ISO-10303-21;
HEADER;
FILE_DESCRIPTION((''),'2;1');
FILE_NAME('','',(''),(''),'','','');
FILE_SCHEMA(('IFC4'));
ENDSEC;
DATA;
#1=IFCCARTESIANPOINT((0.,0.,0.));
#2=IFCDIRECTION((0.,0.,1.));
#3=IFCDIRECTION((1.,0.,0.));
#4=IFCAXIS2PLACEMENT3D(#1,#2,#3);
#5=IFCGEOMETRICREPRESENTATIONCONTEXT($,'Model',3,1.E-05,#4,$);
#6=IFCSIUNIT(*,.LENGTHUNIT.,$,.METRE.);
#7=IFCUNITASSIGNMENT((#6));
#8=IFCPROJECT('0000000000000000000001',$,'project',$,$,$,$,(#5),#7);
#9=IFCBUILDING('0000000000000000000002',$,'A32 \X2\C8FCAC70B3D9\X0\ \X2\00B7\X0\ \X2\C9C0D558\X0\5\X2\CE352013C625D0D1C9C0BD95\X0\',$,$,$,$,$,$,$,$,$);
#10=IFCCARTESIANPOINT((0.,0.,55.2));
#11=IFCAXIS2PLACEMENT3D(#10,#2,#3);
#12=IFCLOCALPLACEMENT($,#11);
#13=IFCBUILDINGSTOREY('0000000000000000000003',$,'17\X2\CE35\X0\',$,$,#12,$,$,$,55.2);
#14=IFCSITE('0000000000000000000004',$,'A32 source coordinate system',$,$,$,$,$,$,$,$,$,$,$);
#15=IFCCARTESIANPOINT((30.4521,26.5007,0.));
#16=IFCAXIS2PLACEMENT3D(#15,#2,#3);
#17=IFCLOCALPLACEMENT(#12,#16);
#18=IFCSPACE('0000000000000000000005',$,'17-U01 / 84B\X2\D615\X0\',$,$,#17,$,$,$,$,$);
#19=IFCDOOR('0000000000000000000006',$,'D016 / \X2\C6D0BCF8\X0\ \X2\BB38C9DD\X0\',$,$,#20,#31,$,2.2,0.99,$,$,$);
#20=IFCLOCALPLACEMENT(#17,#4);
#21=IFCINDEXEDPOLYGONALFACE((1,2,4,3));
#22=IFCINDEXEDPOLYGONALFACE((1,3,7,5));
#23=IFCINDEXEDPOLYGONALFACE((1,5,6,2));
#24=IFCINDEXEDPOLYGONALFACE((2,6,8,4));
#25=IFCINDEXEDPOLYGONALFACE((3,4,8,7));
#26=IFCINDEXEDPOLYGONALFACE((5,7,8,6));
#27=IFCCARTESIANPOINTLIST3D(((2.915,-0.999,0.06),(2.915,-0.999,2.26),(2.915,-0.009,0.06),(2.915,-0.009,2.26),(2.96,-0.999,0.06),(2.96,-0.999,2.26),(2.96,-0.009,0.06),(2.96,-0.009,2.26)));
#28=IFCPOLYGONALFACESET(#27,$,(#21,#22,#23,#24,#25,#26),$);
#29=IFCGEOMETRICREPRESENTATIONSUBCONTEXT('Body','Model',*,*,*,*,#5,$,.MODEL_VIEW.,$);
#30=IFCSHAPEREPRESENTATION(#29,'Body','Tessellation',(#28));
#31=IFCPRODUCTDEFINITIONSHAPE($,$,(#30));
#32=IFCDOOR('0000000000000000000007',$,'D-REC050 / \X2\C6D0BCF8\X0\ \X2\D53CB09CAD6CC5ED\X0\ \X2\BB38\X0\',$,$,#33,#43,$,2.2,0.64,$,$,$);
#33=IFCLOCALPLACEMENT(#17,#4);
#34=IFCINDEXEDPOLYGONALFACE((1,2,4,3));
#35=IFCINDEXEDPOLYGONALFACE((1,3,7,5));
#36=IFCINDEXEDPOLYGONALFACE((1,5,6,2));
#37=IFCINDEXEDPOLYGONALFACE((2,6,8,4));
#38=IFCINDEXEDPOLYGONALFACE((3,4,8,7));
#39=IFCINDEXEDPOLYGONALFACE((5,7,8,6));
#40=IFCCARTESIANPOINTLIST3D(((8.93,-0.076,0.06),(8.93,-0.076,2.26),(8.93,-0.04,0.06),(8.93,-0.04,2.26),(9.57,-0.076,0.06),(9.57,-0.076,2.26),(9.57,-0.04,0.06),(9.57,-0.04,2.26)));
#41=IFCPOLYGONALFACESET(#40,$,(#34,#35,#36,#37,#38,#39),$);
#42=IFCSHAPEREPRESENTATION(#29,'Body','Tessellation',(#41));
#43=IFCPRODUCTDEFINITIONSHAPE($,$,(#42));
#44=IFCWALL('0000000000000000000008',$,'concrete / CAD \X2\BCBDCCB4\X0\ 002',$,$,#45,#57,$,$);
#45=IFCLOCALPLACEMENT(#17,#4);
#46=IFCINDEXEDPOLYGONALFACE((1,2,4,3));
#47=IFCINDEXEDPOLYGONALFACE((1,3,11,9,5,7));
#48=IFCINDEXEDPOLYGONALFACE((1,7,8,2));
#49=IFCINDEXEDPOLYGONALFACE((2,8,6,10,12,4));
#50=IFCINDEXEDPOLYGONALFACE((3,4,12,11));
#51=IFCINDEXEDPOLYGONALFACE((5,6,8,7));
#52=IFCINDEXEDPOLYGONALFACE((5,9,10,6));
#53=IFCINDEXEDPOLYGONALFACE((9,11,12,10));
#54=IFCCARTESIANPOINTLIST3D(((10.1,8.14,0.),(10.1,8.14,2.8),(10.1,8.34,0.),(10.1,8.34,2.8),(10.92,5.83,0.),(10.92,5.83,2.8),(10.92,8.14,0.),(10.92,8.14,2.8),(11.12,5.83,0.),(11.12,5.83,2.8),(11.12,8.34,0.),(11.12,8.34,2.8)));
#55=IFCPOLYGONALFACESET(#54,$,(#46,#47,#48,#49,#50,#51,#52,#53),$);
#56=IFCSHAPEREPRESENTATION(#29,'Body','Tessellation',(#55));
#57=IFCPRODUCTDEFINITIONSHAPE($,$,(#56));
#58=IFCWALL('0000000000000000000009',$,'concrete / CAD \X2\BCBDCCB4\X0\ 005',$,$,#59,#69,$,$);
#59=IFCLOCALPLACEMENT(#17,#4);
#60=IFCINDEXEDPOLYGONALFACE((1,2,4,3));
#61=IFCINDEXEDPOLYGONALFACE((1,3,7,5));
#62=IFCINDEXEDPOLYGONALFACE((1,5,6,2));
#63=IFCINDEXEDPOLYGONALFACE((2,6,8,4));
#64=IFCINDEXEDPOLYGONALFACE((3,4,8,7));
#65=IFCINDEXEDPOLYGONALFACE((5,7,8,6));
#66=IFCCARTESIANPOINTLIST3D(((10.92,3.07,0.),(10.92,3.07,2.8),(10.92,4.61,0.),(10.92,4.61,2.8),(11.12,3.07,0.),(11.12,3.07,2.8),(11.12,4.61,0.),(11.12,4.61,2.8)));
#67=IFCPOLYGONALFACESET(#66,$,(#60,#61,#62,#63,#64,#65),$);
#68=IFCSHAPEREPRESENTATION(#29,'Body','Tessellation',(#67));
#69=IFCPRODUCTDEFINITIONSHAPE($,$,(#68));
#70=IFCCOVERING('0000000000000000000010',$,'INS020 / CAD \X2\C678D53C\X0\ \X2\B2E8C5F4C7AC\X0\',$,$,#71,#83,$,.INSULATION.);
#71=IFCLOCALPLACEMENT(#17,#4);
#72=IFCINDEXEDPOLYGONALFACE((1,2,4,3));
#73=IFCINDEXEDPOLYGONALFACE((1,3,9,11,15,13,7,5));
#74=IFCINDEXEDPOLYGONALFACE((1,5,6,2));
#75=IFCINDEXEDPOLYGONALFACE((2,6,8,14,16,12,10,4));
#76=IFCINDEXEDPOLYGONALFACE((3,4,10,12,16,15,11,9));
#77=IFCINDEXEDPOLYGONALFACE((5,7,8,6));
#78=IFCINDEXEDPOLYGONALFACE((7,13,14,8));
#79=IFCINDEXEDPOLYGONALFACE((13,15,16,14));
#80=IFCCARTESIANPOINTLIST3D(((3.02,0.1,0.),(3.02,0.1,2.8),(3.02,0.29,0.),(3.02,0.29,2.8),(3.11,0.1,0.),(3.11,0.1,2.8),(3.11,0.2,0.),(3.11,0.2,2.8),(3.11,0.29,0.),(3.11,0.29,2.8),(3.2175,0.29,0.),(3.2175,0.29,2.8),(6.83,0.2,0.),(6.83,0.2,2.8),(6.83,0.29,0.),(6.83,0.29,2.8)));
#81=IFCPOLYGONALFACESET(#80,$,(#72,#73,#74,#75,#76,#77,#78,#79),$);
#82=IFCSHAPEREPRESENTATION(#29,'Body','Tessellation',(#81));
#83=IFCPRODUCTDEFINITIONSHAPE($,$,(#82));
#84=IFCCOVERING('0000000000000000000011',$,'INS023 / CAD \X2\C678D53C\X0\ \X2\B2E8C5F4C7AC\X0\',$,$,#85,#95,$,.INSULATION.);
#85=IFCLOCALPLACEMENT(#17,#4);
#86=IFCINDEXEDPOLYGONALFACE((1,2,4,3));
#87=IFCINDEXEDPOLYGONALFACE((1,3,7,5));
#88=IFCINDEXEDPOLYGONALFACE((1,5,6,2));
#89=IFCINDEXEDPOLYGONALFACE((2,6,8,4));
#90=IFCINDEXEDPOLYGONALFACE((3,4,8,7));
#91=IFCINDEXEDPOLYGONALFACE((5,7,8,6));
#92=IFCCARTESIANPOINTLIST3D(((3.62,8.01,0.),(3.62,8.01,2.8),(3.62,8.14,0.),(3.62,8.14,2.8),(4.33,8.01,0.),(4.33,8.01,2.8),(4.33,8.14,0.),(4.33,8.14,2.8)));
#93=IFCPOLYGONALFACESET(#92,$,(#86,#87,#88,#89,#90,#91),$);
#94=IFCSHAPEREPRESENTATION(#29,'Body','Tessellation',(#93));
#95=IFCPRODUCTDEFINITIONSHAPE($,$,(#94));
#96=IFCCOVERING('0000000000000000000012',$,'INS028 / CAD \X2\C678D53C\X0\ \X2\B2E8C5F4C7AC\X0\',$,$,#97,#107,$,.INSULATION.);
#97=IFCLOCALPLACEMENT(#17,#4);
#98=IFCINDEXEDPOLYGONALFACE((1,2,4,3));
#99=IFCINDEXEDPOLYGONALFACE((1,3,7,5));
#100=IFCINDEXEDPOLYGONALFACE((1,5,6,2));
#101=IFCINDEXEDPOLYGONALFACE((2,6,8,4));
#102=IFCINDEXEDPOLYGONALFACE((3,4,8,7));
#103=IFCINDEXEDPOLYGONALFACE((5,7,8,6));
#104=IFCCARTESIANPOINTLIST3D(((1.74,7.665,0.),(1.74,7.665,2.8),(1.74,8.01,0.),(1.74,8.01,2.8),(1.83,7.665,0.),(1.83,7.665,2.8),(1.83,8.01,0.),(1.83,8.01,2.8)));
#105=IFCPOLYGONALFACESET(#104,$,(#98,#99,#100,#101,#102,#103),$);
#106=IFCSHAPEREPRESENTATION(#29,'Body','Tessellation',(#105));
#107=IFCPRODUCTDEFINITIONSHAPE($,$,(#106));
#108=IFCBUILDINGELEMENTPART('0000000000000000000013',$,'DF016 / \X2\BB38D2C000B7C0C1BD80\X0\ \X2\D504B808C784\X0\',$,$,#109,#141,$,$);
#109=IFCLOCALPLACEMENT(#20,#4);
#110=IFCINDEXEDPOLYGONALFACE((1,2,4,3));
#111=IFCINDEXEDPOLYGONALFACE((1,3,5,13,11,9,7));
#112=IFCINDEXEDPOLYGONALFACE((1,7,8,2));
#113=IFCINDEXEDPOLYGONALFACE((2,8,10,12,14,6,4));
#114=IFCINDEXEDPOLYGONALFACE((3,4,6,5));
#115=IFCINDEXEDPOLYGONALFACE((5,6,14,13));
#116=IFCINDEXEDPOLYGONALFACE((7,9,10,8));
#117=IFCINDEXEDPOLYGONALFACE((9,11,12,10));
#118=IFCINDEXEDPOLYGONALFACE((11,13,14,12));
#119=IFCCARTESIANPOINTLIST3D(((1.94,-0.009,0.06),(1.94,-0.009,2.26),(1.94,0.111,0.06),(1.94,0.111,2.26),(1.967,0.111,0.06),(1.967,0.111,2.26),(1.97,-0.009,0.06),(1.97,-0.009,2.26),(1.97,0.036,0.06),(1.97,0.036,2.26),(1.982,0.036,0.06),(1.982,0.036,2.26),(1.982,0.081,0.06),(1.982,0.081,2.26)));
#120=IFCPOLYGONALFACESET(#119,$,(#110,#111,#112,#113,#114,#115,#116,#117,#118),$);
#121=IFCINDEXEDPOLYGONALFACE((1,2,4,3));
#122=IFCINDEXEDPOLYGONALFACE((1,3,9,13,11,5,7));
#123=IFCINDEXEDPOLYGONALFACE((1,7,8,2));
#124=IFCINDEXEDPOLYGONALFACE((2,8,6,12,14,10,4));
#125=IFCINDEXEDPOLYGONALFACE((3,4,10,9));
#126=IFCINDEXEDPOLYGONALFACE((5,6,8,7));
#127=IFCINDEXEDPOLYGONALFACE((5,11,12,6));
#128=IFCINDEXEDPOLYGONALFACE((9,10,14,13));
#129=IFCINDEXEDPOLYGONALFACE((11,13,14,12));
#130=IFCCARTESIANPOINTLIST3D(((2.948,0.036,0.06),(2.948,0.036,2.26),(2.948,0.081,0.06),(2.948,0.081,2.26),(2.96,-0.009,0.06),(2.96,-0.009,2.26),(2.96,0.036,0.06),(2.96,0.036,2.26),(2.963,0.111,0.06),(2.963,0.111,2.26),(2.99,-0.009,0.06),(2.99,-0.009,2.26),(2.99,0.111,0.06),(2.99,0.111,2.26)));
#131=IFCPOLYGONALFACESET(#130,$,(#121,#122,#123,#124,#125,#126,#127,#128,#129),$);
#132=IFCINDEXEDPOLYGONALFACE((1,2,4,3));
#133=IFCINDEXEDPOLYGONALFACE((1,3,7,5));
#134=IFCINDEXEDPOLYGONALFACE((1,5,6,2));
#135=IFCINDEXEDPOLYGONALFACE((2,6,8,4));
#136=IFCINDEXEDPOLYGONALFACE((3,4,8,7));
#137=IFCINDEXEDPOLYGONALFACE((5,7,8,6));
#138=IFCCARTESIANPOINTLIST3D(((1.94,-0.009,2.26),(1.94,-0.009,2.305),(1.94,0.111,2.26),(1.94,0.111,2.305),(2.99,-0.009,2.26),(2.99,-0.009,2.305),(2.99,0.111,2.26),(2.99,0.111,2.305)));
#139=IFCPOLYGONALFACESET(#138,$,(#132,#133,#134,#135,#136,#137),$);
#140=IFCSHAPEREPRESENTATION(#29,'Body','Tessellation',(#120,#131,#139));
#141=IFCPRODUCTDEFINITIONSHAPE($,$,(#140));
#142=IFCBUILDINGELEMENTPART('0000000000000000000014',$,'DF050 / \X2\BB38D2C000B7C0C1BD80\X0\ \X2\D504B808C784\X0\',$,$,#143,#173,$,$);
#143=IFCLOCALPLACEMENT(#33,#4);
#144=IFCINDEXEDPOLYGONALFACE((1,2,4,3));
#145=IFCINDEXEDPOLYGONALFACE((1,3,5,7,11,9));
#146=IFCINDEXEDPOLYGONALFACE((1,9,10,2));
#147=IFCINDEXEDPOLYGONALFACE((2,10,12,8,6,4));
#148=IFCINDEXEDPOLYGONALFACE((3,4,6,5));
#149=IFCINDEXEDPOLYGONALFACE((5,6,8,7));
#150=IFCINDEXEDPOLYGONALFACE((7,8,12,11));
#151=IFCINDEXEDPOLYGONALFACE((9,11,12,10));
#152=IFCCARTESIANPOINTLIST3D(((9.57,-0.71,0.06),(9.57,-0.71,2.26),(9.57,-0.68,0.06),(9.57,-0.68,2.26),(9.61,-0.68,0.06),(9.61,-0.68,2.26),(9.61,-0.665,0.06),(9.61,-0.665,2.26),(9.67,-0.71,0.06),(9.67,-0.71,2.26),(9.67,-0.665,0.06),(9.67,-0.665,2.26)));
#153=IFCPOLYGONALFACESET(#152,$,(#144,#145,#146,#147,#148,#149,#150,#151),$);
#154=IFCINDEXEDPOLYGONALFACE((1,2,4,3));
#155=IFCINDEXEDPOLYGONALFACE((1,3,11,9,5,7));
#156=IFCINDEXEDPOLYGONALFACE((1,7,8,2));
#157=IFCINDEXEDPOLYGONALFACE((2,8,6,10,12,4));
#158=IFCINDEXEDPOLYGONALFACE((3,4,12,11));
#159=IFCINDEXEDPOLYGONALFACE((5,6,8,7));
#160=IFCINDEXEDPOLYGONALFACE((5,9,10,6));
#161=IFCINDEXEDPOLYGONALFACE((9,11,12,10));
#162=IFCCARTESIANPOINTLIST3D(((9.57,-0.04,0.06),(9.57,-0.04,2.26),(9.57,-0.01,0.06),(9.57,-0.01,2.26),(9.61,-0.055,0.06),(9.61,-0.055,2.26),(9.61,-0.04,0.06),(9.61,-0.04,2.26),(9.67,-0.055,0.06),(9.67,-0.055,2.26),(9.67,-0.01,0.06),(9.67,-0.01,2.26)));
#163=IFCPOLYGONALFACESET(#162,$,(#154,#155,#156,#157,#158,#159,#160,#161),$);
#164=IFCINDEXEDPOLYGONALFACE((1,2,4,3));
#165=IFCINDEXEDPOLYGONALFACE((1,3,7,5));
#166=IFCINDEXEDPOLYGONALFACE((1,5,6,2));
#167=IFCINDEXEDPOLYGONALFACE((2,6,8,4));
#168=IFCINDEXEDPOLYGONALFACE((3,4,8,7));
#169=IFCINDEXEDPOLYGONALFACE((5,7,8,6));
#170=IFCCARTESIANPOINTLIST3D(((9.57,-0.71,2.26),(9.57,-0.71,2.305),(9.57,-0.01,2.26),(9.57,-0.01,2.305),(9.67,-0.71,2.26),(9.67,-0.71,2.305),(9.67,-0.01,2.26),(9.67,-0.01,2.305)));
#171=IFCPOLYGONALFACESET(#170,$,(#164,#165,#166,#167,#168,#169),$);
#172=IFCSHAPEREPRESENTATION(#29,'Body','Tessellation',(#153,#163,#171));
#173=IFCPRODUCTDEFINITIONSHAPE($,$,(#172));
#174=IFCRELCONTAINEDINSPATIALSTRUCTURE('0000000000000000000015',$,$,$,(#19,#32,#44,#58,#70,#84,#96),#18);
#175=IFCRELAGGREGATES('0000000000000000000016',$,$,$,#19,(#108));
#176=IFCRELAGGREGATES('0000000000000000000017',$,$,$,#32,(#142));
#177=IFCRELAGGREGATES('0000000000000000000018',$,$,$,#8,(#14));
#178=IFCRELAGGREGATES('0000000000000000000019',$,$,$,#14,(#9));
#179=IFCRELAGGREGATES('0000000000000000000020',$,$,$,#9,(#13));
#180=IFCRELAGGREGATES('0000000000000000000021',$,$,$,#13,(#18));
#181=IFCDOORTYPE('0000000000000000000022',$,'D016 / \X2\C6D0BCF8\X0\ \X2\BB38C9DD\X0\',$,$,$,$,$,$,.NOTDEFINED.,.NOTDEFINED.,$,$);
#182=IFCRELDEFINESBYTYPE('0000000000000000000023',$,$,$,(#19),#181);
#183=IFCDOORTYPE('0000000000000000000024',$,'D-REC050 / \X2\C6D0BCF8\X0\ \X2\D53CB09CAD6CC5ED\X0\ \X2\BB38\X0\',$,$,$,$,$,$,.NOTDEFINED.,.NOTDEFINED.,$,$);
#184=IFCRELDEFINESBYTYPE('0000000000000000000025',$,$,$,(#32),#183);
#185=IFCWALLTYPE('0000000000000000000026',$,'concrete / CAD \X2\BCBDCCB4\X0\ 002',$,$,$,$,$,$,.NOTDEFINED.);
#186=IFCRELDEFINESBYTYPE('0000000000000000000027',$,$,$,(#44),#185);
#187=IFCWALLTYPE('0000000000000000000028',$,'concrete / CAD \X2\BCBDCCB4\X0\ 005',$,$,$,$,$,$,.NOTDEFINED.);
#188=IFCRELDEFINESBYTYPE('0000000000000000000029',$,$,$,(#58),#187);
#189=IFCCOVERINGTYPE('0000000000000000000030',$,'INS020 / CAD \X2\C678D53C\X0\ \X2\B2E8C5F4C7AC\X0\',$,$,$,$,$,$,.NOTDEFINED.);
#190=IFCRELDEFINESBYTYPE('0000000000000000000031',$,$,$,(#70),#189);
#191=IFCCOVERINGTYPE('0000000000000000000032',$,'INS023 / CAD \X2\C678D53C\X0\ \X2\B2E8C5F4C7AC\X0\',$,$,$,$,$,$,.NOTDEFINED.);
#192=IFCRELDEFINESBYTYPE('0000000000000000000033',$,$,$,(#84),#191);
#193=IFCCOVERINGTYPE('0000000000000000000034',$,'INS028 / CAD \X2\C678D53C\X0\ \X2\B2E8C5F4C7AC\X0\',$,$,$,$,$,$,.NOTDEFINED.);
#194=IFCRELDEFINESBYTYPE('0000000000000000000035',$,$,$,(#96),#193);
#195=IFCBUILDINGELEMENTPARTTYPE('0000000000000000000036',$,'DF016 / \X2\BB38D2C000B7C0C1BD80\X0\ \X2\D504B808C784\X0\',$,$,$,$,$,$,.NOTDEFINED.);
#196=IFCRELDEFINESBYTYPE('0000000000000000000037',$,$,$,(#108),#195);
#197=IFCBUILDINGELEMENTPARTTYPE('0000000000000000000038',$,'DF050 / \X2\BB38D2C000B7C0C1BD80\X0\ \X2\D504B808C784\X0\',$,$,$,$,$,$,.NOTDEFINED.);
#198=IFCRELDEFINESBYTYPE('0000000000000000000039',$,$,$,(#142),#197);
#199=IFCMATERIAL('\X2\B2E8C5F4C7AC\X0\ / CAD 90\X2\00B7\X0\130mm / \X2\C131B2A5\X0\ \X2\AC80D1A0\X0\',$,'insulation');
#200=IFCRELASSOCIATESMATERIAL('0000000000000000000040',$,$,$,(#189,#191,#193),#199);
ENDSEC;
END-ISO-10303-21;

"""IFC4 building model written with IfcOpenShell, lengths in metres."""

from ifc_helpers import new_model, si_unit, frame, origin, origin_with_axes, place, context, subcontext, project, spatial, polyline, outline, extrude, source, transform, mapped, material, type_object, type_shapes, element, aggregate, save


model = new_model("IFC4")

# Units and contexts
model_context = context("Model", 3, precision=1e-05, world=origin_with_axes())
body_context = subcontext(model_context, "Body", "Model", "MODEL_VIEW")
ifc_project = project(units=[si_unit("LENGTHUNIT", "METRE")], contexts=[model_context])

# Site, building, storey, space
storey_placement = place(None, frame((0.0, 0.0, 55.2), z_axis=(0.0, 0.0, 1.0), x_axis=(1.0, 0.0, 0.0)))
space_placement = place(storey_placement, frame((30.4521, 26.5007, 0.0), z_axis=(0.0, 0.0, 1.0), x_axis=(1.0, 0.0, 0.0)))
site = spatial("IfcSite", under=ifc_project, Name="A32 source coordinate system")
building = spatial("IfcBuilding", under=site, Name="A32 주거동 · 지하5층–옥탑지붕")
storey = spatial("IfcBuildingStorey", under=building, at=storey_placement, Name="17층", Elevation=55.2)
space = spatial("IfcSpace", under=storey, at=space_placement, Name="17-U01 / 84B형")

# Doors
door_type_1 = type_object("IfcDoorType", Name="D016 / 원본 문짝", OperationType="NOTDEFINED", PredefinedType="NOTDEFINED")
shared_shape_1 = source(origin(), body_context, "Body", "SweptSolid", [
    extrude(outline(polyline([(2.96, -0.009), (2.96, -0.999), (2.915, -0.999), (2.915, -0.009), (2.96, -0.009)])), frame((0.0, 0.0, 0.06)), (0.0, 0.0, 1.0), 2.2),
])
type_shapes(door_type_1, [shared_shape_1])
door_1_placement = place(space_placement, origin_with_axes())
door_1 = element("IfcDoor", 1, at=door_1_placement, inside=space, type_object=door_type_1, Name="D016 / 원본 문짝", OverallHeight=2.2, OverallWidth=0.99, context=body_context, shape_type="MappedRepresentation", body=[
    mapped(shared_shape_1, transform((0.0, 0.0, 0.0), scale=1.0)),
])
door_type_2 = type_object("IfcDoorType", Name="D-REC050 / 원본 피난구역 문", OperationType="NOTDEFINED", PredefinedType="NOTDEFINED")
shared_shape_2 = source(origin(), body_context, "Body", "SweptSolid", [
    extrude(outline(polyline([(9.57, -0.04), (9.57, -0.076), (8.93, -0.076), (8.93, -0.04), (9.57, -0.04)])), frame((0.0, 0.0, 0.06)), (0.0, 0.0, 1.0), 2.2),
])
type_shapes(door_type_2, [shared_shape_2])
door_2_placement = place(space_placement, origin_with_axes())
door_2 = element("IfcDoor", 2, at=door_2_placement, inside=space, type_object=door_type_2, Name="D-REC050 / 원본 피난구역 문", OverallHeight=2.2, OverallWidth=0.64, context=body_context, shape_type="MappedRepresentation", body=[
    mapped(shared_shape_2, transform((0.0, 0.0, 0.0), scale=1.0)),
])

# Walls
wall_type_1 = type_object("IfcWallType", Name="concrete / CAD 벽체 002", PredefinedType="NOTDEFINED")
shared_shape_3 = source(origin(), body_context, "Body", "SweptSolid", [
    extrude(outline(polyline([(11.12, 5.83), (10.92, 5.83), (10.92, 8.14), (10.1, 8.14), (10.1, 8.34), (11.12, 8.34), (11.12, 5.83)])), origin(), (0.0, 0.0, 1.0), 2.8),
])
type_shapes(wall_type_1, [shared_shape_3])
wall_1_placement = place(space_placement, origin_with_axes())
element("IfcWall", 3, at=wall_1_placement, inside=space, type_object=wall_type_1, Name="concrete / CAD 벽체 002", context=body_context, shape_type="MappedRepresentation", body=[
    mapped(shared_shape_3, transform((0.0, 0.0, 0.0), scale=1.0)),
])
wall_type_2 = type_object("IfcWallType", Name="concrete / CAD 벽체 005", PredefinedType="NOTDEFINED")
shared_shape_4 = source(origin(), body_context, "Body", "SweptSolid", [
    extrude(outline(polyline([(11.12, 3.07), (10.92, 3.07), (10.92, 4.61), (11.12, 4.61), (11.12, 3.07)])), origin(), (0.0, 0.0, 1.0), 2.8),
])
type_shapes(wall_type_2, [shared_shape_4])
wall_2_placement = place(space_placement, origin_with_axes())
element("IfcWall", 4, at=wall_2_placement, inside=space, type_object=wall_type_2, Name="concrete / CAD 벽체 005", context=body_context, shape_type="MappedRepresentation", body=[
    mapped(shared_shape_4, transform((0.0, 0.0, 0.0), scale=1.0)),
])

# Coverings
ifc_material = material(Name="단열재 / CAD 90·130mm / 성능 검토", Category="insulation")
covering_type_1 = type_object("IfcCoveringType", Name="INS020 / CAD 외피 단열재", PredefinedType="NOTDEFINED", material=ifc_material)
shared_shape_5 = source(origin(), body_context, "Body", "SweptSolid", [
    extrude(outline(polyline([(3.11, 0.2), (3.11, 0.1), (3.02, 0.1), (3.02, 0.29), (3.11, 0.29), (3.2175, 0.29), (6.83, 0.29), (6.83, 0.2), (3.11, 0.2)])), origin(), (0.0, 0.0, 1.0), 2.8),
])
type_shapes(covering_type_1, [shared_shape_5])
covering_1_placement = place(space_placement, origin_with_axes())
element("IfcCovering", 5, at=covering_1_placement, inside=space, type_object=covering_type_1, Name="INS020 / CAD 외피 단열재", PredefinedType="INSULATION", context=body_context, shape_type="MappedRepresentation", body=[
    mapped(shared_shape_5, transform((0.0, 0.0, 0.0), scale=1.0)),
])
covering_type_2 = type_object("IfcCoveringType", Name="INS023 / CAD 외피 단열재", PredefinedType="NOTDEFINED", material=ifc_material)
shared_shape_6 = source(origin(), body_context, "Body", "SweptSolid", [
    extrude(outline(polyline([(4.33, 8.01), (3.62, 8.01), (3.62, 8.14), (4.33, 8.14), (4.33, 8.01)])), origin(), (0.0, 0.0, 1.0), 2.8),
])
type_shapes(covering_type_2, [shared_shape_6])
covering_2_placement = place(space_placement, origin_with_axes())
element("IfcCovering", 6, at=covering_2_placement, inside=space, type_object=covering_type_2, Name="INS023 / CAD 외피 단열재", PredefinedType="INSULATION", context=body_context, shape_type="MappedRepresentation", body=[
    mapped(shared_shape_6, transform((0.0, 0.0, 0.0), scale=1.0)),
])
covering_type_3 = type_object("IfcCoveringType", Name="INS028 / CAD 외피 단열재", PredefinedType="NOTDEFINED", material=ifc_material)
shared_shape_7 = source(origin(), body_context, "Body", "SweptSolid", [
    extrude(outline(polyline([(1.74, 8.01), (1.83, 8.01), (1.83, 7.665), (1.74, 7.665), (1.74, 8.01)])), origin(), (0.0, 0.0, 1.0), 2.8),
])
type_shapes(covering_type_3, [shared_shape_7])
covering_3_placement = place(space_placement, origin_with_axes())
element("IfcCovering", 7, at=covering_3_placement, inside=space, type_object=covering_type_3, Name="INS028 / CAD 외피 단열재", PredefinedType="INSULATION", context=body_context, shape_type="MappedRepresentation", body=[
    mapped(shared_shape_7, transform((0.0, 0.0, 0.0), scale=1.0)),
])

# Building element parts
building_element_part_type_1 = type_object("IfcBuildingElementPartType", Name="DF016 / 문틀·상부 프레임", PredefinedType="NOTDEFINED")
shared_shape_8 = source(origin(), body_context, "Body", "SweptSolid", [
    extrude(outline(polyline([(1.94, 0.111), (1.967, 0.111), (1.982, 0.081), (1.982, 0.036), (1.97, 0.036), (1.97, -0.009), (1.94, -0.009), (1.94, 0.111)])), frame((0.0, 0.0, 0.06)), (0.0, 0.0, 1.0), 2.2),
    extrude(outline(polyline([(2.96, -0.009), (2.96, 0.036), (2.948, 0.036), (2.948, 0.081), (2.963, 0.111), (2.99, 0.111), (2.99, -0.009), (2.96, -0.009)])), frame((0.0, 0.0, 0.06)), (0.0, 0.0, 1.0), 2.2),
    extrude(outline(polyline([(1.94, -0.009), (1.94, 0.111), (2.99, 0.111), (2.99, -0.009), (1.94, -0.009)])), frame((0.0, 0.0, 2.26)), (0.0, 0.0, 1.0), 0.045),
])
type_shapes(building_element_part_type_1, [shared_shape_8])
building_element_part_1_placement = place(door_1_placement, origin_with_axes())
building_element_part_1 = element("IfcBuildingElementPart", 8, at=building_element_part_1_placement, type_object=building_element_part_type_1, Name="DF016 / 문틀·상부 프레임", context=body_context, shape_type="MappedRepresentation", body=[
    mapped(shared_shape_8, transform((0.0, 0.0, 0.0), scale=1.0)),
])
aggregate(door_1, [building_element_part_1])
building_element_part_type_2 = type_object("IfcBuildingElementPartType", Name="DF050 / 문틀·상부 프레임", PredefinedType="NOTDEFINED")
shared_shape_9 = source(origin(), body_context, "Body", "SweptSolid", [
    extrude(outline(polyline([(9.57, -0.68), (9.61, -0.68), (9.61, -0.665), (9.67, -0.665), (9.67, -0.71), (9.57, -0.71), (9.57, -0.68)])), frame((0.0, 0.0, 0.06)), (0.0, 0.0, 1.0), 2.2),
    extrude(outline(polyline([(9.67, -0.01), (9.67, -0.055), (9.61, -0.055), (9.61, -0.04), (9.57, -0.04), (9.57, -0.01), (9.67, -0.01)])), frame((0.0, 0.0, 0.06)), (0.0, 0.0, 1.0), 2.2),
    extrude(outline(polyline([(9.57, -0.71), (9.57, -0.01), (9.67, -0.01), (9.67, -0.71), (9.57, -0.71)])), frame((0.0, 0.0, 2.26)), (0.0, 0.0, 1.0), 0.045),
])
type_shapes(building_element_part_type_2, [shared_shape_9])
building_element_part_2_placement = place(door_2_placement, origin_with_axes())
building_element_part_2 = element("IfcBuildingElementPart", 9, at=building_element_part_2_placement, type_object=building_element_part_type_2, Name="DF050 / 문틀·상부 프레임", context=body_context, shape_type="MappedRepresentation", body=[
    mapped(shared_shape_9, transform((0.0, 0.0, 0.0), scale=1.0)),
])
aggregate(door_2, [building_element_part_2])

save(model, "model.ifc")
